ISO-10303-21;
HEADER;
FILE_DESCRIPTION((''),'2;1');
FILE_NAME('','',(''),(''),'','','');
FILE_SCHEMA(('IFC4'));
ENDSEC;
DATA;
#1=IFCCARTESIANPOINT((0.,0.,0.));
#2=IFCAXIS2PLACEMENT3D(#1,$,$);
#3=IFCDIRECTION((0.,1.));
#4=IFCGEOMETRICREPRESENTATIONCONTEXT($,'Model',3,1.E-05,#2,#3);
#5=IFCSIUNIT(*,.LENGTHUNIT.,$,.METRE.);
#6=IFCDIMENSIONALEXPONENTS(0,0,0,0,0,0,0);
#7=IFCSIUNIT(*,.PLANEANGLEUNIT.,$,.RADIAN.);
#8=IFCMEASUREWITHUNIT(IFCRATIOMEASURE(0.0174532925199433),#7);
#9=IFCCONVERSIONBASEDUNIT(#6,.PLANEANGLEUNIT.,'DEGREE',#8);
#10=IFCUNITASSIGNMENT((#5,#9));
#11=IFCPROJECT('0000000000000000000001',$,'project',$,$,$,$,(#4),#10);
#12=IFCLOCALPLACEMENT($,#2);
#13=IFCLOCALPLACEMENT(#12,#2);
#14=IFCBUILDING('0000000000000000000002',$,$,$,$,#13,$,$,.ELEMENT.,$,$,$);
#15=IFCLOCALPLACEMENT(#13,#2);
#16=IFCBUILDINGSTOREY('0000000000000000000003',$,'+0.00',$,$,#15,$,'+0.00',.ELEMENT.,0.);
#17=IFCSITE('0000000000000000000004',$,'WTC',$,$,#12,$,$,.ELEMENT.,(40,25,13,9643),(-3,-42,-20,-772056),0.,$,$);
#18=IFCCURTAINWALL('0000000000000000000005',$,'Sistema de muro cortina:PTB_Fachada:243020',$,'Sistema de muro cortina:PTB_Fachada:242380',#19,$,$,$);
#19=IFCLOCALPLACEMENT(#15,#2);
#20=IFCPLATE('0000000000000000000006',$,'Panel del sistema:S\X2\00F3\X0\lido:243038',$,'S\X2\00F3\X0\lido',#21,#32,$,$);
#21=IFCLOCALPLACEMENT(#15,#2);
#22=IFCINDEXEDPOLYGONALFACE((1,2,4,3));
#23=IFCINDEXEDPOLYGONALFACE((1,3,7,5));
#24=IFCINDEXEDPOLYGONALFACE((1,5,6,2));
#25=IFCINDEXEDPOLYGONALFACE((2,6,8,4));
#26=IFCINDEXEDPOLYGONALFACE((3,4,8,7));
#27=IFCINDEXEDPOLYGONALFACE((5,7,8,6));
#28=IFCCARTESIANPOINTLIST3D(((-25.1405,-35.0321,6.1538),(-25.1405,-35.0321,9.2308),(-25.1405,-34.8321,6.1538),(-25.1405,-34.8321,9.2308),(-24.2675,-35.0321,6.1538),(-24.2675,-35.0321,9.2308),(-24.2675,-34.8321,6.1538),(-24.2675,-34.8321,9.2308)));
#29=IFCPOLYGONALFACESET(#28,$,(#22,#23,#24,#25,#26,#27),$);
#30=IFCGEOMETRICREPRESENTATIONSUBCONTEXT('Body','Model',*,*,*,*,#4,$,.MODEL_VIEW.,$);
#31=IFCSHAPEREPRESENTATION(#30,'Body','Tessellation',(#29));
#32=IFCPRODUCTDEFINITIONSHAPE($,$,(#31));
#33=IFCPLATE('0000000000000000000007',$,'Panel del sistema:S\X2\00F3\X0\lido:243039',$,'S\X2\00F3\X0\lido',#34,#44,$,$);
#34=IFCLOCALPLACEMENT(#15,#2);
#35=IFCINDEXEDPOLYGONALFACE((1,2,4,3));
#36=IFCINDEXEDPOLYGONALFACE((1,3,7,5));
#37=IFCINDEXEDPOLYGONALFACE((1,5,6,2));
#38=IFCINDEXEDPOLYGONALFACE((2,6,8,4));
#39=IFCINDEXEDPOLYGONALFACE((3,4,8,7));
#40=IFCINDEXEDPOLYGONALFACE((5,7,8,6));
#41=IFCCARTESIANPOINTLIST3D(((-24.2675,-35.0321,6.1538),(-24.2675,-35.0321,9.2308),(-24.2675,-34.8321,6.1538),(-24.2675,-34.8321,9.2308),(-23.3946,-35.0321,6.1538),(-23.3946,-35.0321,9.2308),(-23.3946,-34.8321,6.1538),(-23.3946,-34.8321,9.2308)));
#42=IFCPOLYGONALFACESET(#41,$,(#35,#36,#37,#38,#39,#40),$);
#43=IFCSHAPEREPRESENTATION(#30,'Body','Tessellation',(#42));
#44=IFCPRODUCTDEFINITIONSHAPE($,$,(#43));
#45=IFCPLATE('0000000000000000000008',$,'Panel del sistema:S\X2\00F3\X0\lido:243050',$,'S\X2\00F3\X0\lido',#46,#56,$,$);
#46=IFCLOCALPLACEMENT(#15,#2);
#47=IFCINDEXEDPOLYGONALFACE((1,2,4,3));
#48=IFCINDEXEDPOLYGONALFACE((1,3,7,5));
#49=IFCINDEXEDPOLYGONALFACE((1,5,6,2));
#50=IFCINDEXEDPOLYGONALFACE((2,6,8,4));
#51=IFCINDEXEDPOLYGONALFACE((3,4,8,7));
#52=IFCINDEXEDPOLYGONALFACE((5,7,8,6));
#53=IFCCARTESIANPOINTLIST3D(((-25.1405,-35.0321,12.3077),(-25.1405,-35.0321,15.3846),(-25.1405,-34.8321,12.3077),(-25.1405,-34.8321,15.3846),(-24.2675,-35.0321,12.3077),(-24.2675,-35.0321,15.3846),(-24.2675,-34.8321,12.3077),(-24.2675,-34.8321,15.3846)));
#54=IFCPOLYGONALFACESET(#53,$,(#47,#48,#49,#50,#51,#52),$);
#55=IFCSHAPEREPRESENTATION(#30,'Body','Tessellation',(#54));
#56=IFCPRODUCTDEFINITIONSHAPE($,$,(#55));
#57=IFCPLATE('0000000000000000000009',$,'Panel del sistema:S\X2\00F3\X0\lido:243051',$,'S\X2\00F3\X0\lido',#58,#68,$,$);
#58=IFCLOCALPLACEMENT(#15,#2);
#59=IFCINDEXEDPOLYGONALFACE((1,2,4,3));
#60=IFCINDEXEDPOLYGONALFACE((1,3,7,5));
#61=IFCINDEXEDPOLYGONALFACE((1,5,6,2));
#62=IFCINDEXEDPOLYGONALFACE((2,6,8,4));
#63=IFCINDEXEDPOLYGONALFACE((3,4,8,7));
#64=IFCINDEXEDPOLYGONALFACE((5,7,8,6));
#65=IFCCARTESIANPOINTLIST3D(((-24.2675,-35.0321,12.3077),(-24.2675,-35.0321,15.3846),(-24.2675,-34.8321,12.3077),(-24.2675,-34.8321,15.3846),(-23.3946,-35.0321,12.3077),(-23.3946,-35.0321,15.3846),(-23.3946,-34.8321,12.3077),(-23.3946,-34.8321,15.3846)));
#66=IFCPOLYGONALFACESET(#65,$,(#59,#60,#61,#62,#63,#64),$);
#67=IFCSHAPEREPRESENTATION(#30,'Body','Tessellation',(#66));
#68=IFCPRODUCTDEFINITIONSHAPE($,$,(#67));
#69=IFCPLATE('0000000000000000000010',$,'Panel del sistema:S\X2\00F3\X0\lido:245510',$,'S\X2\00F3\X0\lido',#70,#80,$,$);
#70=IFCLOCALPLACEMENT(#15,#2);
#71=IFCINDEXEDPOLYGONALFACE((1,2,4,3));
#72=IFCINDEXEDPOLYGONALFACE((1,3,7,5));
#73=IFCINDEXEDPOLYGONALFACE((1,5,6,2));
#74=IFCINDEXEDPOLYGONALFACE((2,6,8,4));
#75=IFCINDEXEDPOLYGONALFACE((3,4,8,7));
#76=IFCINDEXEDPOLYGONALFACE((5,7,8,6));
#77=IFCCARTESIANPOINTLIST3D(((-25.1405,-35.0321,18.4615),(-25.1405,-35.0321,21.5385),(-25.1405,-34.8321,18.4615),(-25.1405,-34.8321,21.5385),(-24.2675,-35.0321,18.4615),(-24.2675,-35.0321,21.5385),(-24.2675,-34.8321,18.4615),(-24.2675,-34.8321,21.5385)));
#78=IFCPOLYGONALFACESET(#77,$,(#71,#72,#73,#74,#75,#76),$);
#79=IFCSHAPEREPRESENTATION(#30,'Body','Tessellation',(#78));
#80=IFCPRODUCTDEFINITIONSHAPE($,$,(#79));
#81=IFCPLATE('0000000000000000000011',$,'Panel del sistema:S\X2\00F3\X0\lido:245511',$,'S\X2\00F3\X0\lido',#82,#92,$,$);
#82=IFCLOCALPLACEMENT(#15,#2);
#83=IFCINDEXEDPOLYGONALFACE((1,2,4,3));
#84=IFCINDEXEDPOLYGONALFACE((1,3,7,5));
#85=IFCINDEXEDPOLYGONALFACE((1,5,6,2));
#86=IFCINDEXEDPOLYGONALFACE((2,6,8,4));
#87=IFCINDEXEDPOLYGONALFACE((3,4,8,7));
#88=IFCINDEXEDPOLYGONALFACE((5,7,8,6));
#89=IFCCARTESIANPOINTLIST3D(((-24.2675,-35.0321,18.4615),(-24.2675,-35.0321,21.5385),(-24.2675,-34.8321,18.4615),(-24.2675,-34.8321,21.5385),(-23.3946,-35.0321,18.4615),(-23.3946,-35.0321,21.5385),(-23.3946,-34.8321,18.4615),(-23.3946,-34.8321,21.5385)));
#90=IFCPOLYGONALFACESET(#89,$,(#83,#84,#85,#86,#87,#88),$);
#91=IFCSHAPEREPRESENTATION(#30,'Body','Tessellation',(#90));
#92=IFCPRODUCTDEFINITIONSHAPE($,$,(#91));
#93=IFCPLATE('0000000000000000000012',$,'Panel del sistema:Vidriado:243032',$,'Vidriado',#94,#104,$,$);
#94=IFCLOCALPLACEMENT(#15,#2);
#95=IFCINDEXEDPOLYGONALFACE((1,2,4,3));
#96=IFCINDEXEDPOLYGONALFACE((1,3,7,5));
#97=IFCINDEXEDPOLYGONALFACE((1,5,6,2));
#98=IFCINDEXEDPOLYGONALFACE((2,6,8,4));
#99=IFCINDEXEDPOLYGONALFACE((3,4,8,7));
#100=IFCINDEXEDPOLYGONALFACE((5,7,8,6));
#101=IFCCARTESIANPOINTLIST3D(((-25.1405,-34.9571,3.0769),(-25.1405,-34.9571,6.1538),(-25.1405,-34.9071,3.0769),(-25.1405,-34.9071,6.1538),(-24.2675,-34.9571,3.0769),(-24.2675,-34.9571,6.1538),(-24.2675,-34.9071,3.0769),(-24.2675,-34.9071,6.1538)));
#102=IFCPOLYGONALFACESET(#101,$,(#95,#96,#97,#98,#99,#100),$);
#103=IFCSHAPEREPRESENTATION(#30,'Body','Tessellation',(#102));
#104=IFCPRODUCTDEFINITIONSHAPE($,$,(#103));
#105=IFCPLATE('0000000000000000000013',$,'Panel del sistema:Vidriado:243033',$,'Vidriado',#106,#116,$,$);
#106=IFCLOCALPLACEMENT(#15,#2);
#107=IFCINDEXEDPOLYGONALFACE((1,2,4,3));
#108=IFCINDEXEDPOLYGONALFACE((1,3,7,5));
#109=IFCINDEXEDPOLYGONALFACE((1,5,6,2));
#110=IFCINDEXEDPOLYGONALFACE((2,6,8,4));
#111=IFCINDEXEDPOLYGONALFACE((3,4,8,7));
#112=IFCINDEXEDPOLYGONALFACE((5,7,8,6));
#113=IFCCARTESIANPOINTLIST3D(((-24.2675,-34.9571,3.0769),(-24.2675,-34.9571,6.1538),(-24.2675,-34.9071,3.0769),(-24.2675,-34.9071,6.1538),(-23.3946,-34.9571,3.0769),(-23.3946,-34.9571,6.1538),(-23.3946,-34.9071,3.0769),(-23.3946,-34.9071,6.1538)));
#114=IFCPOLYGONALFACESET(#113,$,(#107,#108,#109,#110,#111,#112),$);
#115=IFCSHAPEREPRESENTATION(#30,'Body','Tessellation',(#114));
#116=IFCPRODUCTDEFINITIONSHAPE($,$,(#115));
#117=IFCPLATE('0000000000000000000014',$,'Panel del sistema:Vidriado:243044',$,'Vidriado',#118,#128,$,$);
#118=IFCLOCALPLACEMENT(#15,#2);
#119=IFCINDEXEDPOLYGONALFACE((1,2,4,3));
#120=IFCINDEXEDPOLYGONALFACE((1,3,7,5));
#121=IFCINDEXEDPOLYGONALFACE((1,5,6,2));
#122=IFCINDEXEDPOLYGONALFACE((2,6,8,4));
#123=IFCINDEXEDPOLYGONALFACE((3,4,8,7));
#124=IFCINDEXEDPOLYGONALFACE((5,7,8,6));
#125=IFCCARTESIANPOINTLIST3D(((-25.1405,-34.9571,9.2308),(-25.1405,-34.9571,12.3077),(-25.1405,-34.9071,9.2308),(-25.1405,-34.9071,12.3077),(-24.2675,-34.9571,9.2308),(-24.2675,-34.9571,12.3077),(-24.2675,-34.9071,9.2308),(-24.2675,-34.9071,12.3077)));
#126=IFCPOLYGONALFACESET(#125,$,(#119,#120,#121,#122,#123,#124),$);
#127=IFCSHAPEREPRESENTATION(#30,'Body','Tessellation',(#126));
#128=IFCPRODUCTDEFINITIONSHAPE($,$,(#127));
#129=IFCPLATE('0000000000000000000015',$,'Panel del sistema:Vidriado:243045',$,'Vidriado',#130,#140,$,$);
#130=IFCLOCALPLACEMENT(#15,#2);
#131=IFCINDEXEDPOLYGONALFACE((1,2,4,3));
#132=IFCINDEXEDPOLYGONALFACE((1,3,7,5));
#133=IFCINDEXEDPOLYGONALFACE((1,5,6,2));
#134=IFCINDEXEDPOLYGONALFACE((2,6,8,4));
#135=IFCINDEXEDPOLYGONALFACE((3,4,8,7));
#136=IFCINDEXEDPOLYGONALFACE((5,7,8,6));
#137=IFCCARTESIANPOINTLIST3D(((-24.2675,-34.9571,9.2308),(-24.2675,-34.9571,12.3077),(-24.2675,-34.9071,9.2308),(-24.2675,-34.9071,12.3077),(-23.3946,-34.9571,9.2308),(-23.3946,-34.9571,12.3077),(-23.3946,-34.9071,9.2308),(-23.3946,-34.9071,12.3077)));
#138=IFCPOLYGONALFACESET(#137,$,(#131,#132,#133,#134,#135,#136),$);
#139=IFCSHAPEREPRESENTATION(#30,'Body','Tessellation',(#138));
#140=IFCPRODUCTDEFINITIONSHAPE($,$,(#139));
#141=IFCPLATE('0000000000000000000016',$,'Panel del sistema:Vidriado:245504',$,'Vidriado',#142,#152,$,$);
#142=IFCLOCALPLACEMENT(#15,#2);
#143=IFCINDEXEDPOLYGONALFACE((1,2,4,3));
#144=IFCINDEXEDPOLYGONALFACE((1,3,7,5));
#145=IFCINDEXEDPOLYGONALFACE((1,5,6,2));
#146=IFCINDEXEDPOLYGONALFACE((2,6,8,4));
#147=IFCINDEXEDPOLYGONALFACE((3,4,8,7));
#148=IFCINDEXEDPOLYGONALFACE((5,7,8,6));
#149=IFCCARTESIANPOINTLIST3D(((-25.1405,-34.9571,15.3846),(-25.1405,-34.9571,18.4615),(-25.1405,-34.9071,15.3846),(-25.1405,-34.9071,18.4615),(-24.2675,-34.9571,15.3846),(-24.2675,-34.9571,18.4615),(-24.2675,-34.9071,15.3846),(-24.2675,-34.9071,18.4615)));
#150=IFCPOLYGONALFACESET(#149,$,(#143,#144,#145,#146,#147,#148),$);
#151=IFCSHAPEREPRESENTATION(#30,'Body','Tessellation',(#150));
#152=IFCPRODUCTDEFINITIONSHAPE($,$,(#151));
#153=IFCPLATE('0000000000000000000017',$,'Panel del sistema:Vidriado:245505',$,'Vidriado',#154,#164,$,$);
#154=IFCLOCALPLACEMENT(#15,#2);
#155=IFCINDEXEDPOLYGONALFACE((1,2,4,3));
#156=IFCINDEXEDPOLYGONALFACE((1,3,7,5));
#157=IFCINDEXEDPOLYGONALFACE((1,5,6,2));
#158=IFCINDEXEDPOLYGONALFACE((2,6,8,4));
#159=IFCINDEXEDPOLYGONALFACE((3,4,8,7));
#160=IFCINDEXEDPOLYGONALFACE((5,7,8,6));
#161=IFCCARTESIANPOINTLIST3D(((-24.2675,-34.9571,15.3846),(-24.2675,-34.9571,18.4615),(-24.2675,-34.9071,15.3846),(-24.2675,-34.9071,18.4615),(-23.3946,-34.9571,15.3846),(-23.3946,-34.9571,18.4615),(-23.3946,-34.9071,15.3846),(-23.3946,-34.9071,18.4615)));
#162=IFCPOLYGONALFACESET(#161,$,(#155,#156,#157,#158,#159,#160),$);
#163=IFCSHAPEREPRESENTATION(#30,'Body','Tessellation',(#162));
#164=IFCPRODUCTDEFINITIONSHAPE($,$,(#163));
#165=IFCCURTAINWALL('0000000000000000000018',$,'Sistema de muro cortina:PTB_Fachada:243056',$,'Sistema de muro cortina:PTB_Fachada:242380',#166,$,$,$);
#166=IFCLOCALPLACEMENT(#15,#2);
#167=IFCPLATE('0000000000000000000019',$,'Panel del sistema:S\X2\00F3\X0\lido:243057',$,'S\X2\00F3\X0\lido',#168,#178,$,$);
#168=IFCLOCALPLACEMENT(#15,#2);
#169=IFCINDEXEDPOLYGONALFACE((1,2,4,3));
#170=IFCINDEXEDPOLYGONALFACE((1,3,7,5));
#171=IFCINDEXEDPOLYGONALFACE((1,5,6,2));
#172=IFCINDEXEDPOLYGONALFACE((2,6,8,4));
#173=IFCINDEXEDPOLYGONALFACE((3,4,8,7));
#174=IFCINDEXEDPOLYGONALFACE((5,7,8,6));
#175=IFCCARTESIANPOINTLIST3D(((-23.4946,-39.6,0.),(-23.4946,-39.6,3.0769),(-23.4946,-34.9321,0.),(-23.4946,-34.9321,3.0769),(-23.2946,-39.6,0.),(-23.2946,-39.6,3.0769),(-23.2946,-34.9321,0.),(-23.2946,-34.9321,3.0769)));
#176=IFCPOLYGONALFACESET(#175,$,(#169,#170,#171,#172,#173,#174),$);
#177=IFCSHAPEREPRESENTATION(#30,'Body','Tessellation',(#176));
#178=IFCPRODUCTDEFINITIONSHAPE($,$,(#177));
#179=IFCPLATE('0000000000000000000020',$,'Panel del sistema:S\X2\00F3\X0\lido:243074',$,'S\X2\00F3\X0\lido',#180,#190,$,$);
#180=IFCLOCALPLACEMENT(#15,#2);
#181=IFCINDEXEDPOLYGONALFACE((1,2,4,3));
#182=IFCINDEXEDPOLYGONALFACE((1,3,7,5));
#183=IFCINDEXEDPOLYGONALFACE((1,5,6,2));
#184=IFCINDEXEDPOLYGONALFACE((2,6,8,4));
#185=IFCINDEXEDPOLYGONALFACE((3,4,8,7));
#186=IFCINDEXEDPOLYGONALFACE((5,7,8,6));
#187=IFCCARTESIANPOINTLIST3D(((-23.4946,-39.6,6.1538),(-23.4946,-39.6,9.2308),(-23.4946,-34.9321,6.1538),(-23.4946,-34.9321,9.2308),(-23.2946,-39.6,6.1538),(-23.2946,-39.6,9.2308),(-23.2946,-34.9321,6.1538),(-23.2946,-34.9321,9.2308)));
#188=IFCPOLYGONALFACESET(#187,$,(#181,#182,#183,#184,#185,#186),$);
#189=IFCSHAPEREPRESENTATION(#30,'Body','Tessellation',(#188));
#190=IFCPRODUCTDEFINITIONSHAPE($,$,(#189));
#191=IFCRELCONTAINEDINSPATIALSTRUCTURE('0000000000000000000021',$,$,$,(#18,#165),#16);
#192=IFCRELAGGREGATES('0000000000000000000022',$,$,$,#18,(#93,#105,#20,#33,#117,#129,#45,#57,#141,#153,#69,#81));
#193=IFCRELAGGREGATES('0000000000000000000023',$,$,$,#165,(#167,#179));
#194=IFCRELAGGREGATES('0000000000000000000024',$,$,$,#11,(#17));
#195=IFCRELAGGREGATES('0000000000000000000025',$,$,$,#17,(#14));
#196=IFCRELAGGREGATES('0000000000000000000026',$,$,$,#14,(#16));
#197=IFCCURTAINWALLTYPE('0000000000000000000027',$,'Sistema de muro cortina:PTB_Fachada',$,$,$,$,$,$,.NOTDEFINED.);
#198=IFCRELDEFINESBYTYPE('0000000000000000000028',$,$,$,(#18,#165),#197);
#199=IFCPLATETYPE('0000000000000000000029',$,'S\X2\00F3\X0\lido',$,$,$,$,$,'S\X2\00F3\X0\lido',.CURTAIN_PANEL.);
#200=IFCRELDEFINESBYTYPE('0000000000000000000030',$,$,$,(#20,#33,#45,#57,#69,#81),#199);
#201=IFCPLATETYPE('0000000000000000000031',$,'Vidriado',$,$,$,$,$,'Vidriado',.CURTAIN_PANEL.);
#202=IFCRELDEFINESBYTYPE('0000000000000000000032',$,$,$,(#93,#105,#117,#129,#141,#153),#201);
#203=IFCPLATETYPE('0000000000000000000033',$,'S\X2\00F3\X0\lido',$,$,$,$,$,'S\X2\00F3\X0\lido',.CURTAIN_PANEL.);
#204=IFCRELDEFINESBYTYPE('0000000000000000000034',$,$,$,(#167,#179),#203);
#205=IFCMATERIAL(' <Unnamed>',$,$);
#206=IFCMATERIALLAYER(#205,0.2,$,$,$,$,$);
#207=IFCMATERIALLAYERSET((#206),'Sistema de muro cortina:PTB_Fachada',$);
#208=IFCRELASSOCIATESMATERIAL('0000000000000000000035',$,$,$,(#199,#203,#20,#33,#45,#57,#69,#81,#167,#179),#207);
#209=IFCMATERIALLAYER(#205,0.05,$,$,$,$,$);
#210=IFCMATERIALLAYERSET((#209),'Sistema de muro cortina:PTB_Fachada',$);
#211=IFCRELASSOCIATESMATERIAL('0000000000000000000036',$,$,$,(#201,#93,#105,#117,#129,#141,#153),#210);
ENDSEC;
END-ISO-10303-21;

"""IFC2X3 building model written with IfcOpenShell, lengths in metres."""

from ifc_helpers import new_model, entity, si_unit, converted_unit, direction, frame, origin, origin_2d_with_axis, place, context, subcontext, project, spatial, rectangle, extrude, source, transform, mapped, material, layer, layer_set, layer_usage, type_object, type_shapes, element, aggregate, save


model = new_model("IFC2X3")

# Units and contexts
model_context = context("Model", 3, precision=1e-05, world=origin(), true_north=direction((0.0, 1.0)))
body_context = subcontext(model_context, "Body", "Model", "MODEL_VIEW")
ifc_project = project(units=[si_unit("LENGTHUNIT", "METRE"), converted_unit("PLANEANGLEUNIT", "DEGREE", entity("IfcRatioMeasure", 0.0174532925199433), si_unit("PLANEANGLEUNIT", "RADIAN"), dimensions=[0, 0, 0, 0, 0, 0, 0])], contexts=[model_context])

# Site, building, storey
site_placement = place(None, origin())
site = spatial("IfcSite", under=ifc_project, at=site_placement, Name="WTC", CompositionType="ELEMENT", RefLatitude=(40, 25, 13, 9643), RefLongitude=(-3, -42, -20, -772056), RefElevation=0.0)
building_placement = place(site_placement, origin())
building = spatial("IfcBuilding", under=site, at=building_placement, CompositionType="ELEMENT")
storey_placement = place(building_placement, origin())
storey = spatial("IfcBuildingStorey", under=building, at=storey_placement, Name="+0.00", LongName="+0.00", CompositionType="ELEMENT", Elevation=0.0)

# Curtain walls, plates
curtain_wall_type = type_object("IfcCurtainWallType", Name="Sistema de muro cortina:PTB_Fachada", PredefinedType="NOTDEFINED")
ifc_material_1 = material(Name=" <Unnamed>")
ifc_layer_1 = layer(ifc_material_1, 0.2)
ifc_layer_set_1 = layer_set([ifc_layer_1], Name="Sistema de muro cortina:PTB_Fachada")
ifc_layer_2 = layer(ifc_material_1, 0.05)
ifc_layer_set_2 = layer_set([ifc_layer_2], Name="Sistema de muro cortina:PTB_Fachada")
curtain_wall_1_placement = place(storey_placement, origin())
curtain_wall_1 = element("IfcCurtainWall", 1, at=curtain_wall_1_placement, inside=storey, type_object=curtain_wall_type, Name="Sistema de muro cortina:PTB_Fachada:243020", ObjectType="Sistema de muro cortina:PTB_Fachada:242380")
plate_type_1 = type_object("IfcPlateType", Name="Sólido", ElementType="Sólido", PredefinedType="CURTAIN_PANEL", material=ifc_layer_set_1)
shared_shape_1 = source(origin(), body_context, "Body", "SweptSolid", [
    extrude(rectangle(XDim=0.2, YDim=0.873, at=origin_2d_with_axis()), frame((0.0, 0.0, 0.0), z_axis=(0.0, 0.0, 1.0), x_axis=(0.0, 1.0, 0.0)), (0.0, 0.0, 1.0), 3.0769),
])
type_shapes(plate_type_1, [shared_shape_1])
ifc_layer_usage_1 = layer_usage(ifc_layer_set_1, "AXIS3", "POSITIVE", 0.0)
plate_1_placement = place(curtain_wall_1_placement, frame((-24.704, -34.9321, 6.1538)))
plate_1 = element("IfcPlate", 2, at=plate_1_placement, type_object=plate_type_1, material=ifc_layer_usage_1, Name="Panel del sistema:Sólido:243038", ObjectType="Sólido", context=body_context, shape_type="MappedRepresentation", body=[
    mapped(shared_shape_1, transform((0.0, 0.0, 0.0), scale=1.0)),
])
ifc_layer_usage_2 = layer_usage(ifc_layer_set_1, "AXIS3", "POSITIVE", 0.0)
plate_2_placement = place(curtain_wall_1_placement, frame((-23.831, -34.9321, 6.1538)))
plate_2 = element("IfcPlate", 3, at=plate_2_placement, type_object=plate_type_1, material=ifc_layer_usage_2, Name="Panel del sistema:Sólido:243039", ObjectType="Sólido", context=body_context, shape_type="MappedRepresentation", body=[
    mapped(shared_shape_1, transform((0.0, 0.0, 0.0), scale=1.0)),
])
ifc_layer_usage_3 = layer_usage(ifc_layer_set_1, "AXIS3", "POSITIVE", 0.0)
plate_3_placement = place(curtain_wall_1_placement, frame((-24.704, -34.9321, 12.3077)))
plate_3 = element("IfcPlate", 4, at=plate_3_placement, type_object=plate_type_1, material=ifc_layer_usage_3, Name="Panel del sistema:Sólido:243050", ObjectType="Sólido", context=body_context, shape_type="MappedRepresentation", body=[
    mapped(shared_shape_1, transform((0.0, 0.0, 0.0), scale=1.0)),
])
ifc_layer_usage_4 = layer_usage(ifc_layer_set_1, "AXIS3", "POSITIVE", 0.0)
plate_4_placement = place(curtain_wall_1_placement, frame((-23.831, -34.9321, 12.3077)))
plate_4 = element("IfcPlate", 5, at=plate_4_placement, type_object=plate_type_1, material=ifc_layer_usage_4, Name="Panel del sistema:Sólido:243051", ObjectType="Sólido", context=body_context, shape_type="MappedRepresentation", body=[
    mapped(shared_shape_1, transform((0.0, 0.0, 0.0), scale=1.0)),
])
ifc_layer_usage_5 = layer_usage(ifc_layer_set_1, "AXIS3", "POSITIVE", 0.0)
plate_5_placement = place(curtain_wall_1_placement, frame((-24.704, -34.9321, 18.4615)))
plate_5 = element("IfcPlate", 6, at=plate_5_placement, type_object=plate_type_1, material=ifc_layer_usage_5, Name="Panel del sistema:Sólido:245510", ObjectType="Sólido", context=body_context, shape_type="MappedRepresentation", body=[
    mapped(shared_shape_1, transform((0.0, 0.0, 0.0), scale=1.0)),
])
ifc_layer_usage_6 = layer_usage(ifc_layer_set_1, "AXIS3", "POSITIVE", 0.0)
plate_6_placement = place(curtain_wall_1_placement, frame((-23.831, -34.9321, 18.4615)))
plate_6 = element("IfcPlate", 7, at=plate_6_placement, type_object=plate_type_1, material=ifc_layer_usage_6, Name="Panel del sistema:Sólido:245511", ObjectType="Sólido", context=body_context, shape_type="MappedRepresentation", body=[
    mapped(shared_shape_1, transform((0.0, 0.0, 0.0), scale=1.0)),
])
ifc_layer_usage_7 = layer_usage(ifc_layer_set_2, "AXIS3", "POSITIVE", 0.0)
plate_type_2 = type_object("IfcPlateType", Name="Vidriado", ElementType="Vidriado", PredefinedType="CURTAIN_PANEL", material=ifc_layer_set_2)
shared_shape_2 = source(origin(), body_context, "Body", "SweptSolid", [
    extrude(rectangle(XDim=0.05, YDim=0.873, at=origin_2d_with_axis()), frame((0.0, 0.0, 0.0), z_axis=(0.0, 0.0, 1.0), x_axis=(0.0, 1.0, 0.0)), (0.0, 0.0, 1.0), 3.0769),
])
type_shapes(plate_type_2, [shared_shape_2])
plate_7_placement = place(curtain_wall_1_placement, frame((-24.704, -34.9321, 3.0769)))
plate_7 = element("IfcPlate", 8, at=plate_7_placement, type_object=plate_type_2, material=ifc_layer_usage_7, Name="Panel del sistema:Vidriado:243032", ObjectType="Vidriado", context=body_context, shape_type="MappedRepresentation", body=[
    mapped(shared_shape_2, transform((0.0, 0.0, 0.0), scale=1.0)),
])
ifc_layer_usage_8 = layer_usage(ifc_layer_set_2, "AXIS3", "POSITIVE", 0.0)
plate_8_placement = place(curtain_wall_1_placement, frame((-23.831, -34.9321, 3.0769)))
plate_8 = element("IfcPlate", 9, at=plate_8_placement, type_object=plate_type_2, material=ifc_layer_usage_8, Name="Panel del sistema:Vidriado:243033", ObjectType="Vidriado", context=body_context, shape_type="MappedRepresentation", body=[
    mapped(shared_shape_2, transform((0.0, 0.0, 0.0), scale=1.0)),
])
ifc_layer_usage_9 = layer_usage(ifc_layer_set_2, "AXIS3", "POSITIVE", 0.0)
plate_9_placement = place(curtain_wall_1_placement, frame((-24.704, -34.9321, 9.2308)))
plate_9 = element("IfcPlate", 10, at=plate_9_placement, type_object=plate_type_2, material=ifc_layer_usage_9, Name="Panel del sistema:Vidriado:243044", ObjectType="Vidriado", context=body_context, shape_type="MappedRepresentation", body=[
    mapped(shared_shape_2, transform((0.0, 0.0, 0.0), scale=1.0)),
])
ifc_layer_usage_10 = layer_usage(ifc_layer_set_2, "AXIS3", "POSITIVE", 0.0)
plate_10_placement = place(curtain_wall_1_placement, frame((-23.831, -34.9321, 9.2308)))
plate_10 = element("IfcPlate", 11, at=plate_10_placement, type_object=plate_type_2, material=ifc_layer_usage_10, Name="Panel del sistema:Vidriado:243045", ObjectType="Vidriado", context=body_context, shape_type="MappedRepresentation", body=[
    mapped(shared_shape_2, transform((0.0, 0.0, 0.0), scale=1.0)),
])
ifc_layer_usage_11 = layer_usage(ifc_layer_set_2, "AXIS3", "POSITIVE", 0.0)
plate_11_placement = place(curtain_wall_1_placement, frame((-24.704, -34.9321, 15.3846)))
plate_11 = element("IfcPlate", 12, at=plate_11_placement, type_object=plate_type_2, material=ifc_layer_usage_11, Name="Panel del sistema:Vidriado:245504", ObjectType="Vidriado", context=body_context, shape_type="MappedRepresentation", body=[
    mapped(shared_shape_2, transform((0.0, 0.0, 0.0), scale=1.0)),
])
ifc_layer_usage_12 = layer_usage(ifc_layer_set_2, "AXIS3", "POSITIVE", 0.0)
plate_12_placement = place(curtain_wall_1_placement, frame((-23.831, -34.9321, 15.3846)))
plate_12 = element("IfcPlate", 13, at=plate_12_placement, type_object=plate_type_2, material=ifc_layer_usage_12, Name="Panel del sistema:Vidriado:245505", ObjectType="Vidriado", context=body_context, shape_type="MappedRepresentation", body=[
    mapped(shared_shape_2, transform((0.0, 0.0, 0.0), scale=1.0)),
])
aggregate(curtain_wall_1, [plate_7, plate_8, plate_1, plate_2, plate_9, plate_10, plate_3, plate_4, plate_11, plate_12, plate_5, plate_6])
curtain_wall_2_placement = place(storey_placement, origin())
curtain_wall_2 = element("IfcCurtainWall", 14, at=curtain_wall_2_placement, inside=storey, type_object=curtain_wall_type, Name="Sistema de muro cortina:PTB_Fachada:243056", ObjectType="Sistema de muro cortina:PTB_Fachada:242380")
ifc_layer_usage_13 = layer_usage(ifc_layer_set_1, "AXIS3", "POSITIVE", 0.0)
plate_type_3 = type_object("IfcPlateType", Name="Sólido", ElementType="Sólido", PredefinedType="CURTAIN_PANEL", material=ifc_layer_set_1)
shared_shape_3 = source(origin(), body_context, "Body", "SweptSolid", [
    extrude(rectangle(XDim=0.2, YDim=4.6679, at=origin_2d_with_axis()), frame((0.0, 0.0, 0.0), z_axis=(0.0, 0.0, 1.0), x_axis=(0.0, 1.0, 0.0)), (0.0, 0.0, 1.0), 3.0769),
])
type_shapes(plate_type_3, [shared_shape_3])
plate_13_placement = place(curtain_wall_2_placement, frame((-23.3946, -37.266, 0.0), z_axis=(0.0, 0.0, 1.0), x_axis=(0.0, -1.0, 0.0)))
plate_13 = element("IfcPlate", 15, at=plate_13_placement, type_object=plate_type_3, material=ifc_layer_usage_13, Name="Panel del sistema:Sólido:243057", ObjectType="Sólido", context=body_context, shape_type="MappedRepresentation", body=[
    mapped(shared_shape_3, transform((0.0, 0.0, 0.0), scale=1.0)),
])
ifc_layer_usage_14 = layer_usage(ifc_layer_set_1, "AXIS3", "POSITIVE", 0.0)
plate_14_placement = place(curtain_wall_2_placement, frame((-23.3946, -37.266, 6.1538), z_axis=(0.0, 0.0, 1.0), x_axis=(0.0, -1.0, 0.0)))
plate_14 = element("IfcPlate", 16, at=plate_14_placement, type_object=plate_type_3, material=ifc_layer_usage_14, Name="Panel del sistema:Sólido:243074", ObjectType="Sólido", context=body_context, shape_type="MappedRepresentation", body=[
    mapped(shared_shape_3, transform((0.0, 0.0, 0.0), scale=1.0)),
])
aggregate(curtain_wall_2, [plate_13, plate_14])

save(model, "model.ifc")
